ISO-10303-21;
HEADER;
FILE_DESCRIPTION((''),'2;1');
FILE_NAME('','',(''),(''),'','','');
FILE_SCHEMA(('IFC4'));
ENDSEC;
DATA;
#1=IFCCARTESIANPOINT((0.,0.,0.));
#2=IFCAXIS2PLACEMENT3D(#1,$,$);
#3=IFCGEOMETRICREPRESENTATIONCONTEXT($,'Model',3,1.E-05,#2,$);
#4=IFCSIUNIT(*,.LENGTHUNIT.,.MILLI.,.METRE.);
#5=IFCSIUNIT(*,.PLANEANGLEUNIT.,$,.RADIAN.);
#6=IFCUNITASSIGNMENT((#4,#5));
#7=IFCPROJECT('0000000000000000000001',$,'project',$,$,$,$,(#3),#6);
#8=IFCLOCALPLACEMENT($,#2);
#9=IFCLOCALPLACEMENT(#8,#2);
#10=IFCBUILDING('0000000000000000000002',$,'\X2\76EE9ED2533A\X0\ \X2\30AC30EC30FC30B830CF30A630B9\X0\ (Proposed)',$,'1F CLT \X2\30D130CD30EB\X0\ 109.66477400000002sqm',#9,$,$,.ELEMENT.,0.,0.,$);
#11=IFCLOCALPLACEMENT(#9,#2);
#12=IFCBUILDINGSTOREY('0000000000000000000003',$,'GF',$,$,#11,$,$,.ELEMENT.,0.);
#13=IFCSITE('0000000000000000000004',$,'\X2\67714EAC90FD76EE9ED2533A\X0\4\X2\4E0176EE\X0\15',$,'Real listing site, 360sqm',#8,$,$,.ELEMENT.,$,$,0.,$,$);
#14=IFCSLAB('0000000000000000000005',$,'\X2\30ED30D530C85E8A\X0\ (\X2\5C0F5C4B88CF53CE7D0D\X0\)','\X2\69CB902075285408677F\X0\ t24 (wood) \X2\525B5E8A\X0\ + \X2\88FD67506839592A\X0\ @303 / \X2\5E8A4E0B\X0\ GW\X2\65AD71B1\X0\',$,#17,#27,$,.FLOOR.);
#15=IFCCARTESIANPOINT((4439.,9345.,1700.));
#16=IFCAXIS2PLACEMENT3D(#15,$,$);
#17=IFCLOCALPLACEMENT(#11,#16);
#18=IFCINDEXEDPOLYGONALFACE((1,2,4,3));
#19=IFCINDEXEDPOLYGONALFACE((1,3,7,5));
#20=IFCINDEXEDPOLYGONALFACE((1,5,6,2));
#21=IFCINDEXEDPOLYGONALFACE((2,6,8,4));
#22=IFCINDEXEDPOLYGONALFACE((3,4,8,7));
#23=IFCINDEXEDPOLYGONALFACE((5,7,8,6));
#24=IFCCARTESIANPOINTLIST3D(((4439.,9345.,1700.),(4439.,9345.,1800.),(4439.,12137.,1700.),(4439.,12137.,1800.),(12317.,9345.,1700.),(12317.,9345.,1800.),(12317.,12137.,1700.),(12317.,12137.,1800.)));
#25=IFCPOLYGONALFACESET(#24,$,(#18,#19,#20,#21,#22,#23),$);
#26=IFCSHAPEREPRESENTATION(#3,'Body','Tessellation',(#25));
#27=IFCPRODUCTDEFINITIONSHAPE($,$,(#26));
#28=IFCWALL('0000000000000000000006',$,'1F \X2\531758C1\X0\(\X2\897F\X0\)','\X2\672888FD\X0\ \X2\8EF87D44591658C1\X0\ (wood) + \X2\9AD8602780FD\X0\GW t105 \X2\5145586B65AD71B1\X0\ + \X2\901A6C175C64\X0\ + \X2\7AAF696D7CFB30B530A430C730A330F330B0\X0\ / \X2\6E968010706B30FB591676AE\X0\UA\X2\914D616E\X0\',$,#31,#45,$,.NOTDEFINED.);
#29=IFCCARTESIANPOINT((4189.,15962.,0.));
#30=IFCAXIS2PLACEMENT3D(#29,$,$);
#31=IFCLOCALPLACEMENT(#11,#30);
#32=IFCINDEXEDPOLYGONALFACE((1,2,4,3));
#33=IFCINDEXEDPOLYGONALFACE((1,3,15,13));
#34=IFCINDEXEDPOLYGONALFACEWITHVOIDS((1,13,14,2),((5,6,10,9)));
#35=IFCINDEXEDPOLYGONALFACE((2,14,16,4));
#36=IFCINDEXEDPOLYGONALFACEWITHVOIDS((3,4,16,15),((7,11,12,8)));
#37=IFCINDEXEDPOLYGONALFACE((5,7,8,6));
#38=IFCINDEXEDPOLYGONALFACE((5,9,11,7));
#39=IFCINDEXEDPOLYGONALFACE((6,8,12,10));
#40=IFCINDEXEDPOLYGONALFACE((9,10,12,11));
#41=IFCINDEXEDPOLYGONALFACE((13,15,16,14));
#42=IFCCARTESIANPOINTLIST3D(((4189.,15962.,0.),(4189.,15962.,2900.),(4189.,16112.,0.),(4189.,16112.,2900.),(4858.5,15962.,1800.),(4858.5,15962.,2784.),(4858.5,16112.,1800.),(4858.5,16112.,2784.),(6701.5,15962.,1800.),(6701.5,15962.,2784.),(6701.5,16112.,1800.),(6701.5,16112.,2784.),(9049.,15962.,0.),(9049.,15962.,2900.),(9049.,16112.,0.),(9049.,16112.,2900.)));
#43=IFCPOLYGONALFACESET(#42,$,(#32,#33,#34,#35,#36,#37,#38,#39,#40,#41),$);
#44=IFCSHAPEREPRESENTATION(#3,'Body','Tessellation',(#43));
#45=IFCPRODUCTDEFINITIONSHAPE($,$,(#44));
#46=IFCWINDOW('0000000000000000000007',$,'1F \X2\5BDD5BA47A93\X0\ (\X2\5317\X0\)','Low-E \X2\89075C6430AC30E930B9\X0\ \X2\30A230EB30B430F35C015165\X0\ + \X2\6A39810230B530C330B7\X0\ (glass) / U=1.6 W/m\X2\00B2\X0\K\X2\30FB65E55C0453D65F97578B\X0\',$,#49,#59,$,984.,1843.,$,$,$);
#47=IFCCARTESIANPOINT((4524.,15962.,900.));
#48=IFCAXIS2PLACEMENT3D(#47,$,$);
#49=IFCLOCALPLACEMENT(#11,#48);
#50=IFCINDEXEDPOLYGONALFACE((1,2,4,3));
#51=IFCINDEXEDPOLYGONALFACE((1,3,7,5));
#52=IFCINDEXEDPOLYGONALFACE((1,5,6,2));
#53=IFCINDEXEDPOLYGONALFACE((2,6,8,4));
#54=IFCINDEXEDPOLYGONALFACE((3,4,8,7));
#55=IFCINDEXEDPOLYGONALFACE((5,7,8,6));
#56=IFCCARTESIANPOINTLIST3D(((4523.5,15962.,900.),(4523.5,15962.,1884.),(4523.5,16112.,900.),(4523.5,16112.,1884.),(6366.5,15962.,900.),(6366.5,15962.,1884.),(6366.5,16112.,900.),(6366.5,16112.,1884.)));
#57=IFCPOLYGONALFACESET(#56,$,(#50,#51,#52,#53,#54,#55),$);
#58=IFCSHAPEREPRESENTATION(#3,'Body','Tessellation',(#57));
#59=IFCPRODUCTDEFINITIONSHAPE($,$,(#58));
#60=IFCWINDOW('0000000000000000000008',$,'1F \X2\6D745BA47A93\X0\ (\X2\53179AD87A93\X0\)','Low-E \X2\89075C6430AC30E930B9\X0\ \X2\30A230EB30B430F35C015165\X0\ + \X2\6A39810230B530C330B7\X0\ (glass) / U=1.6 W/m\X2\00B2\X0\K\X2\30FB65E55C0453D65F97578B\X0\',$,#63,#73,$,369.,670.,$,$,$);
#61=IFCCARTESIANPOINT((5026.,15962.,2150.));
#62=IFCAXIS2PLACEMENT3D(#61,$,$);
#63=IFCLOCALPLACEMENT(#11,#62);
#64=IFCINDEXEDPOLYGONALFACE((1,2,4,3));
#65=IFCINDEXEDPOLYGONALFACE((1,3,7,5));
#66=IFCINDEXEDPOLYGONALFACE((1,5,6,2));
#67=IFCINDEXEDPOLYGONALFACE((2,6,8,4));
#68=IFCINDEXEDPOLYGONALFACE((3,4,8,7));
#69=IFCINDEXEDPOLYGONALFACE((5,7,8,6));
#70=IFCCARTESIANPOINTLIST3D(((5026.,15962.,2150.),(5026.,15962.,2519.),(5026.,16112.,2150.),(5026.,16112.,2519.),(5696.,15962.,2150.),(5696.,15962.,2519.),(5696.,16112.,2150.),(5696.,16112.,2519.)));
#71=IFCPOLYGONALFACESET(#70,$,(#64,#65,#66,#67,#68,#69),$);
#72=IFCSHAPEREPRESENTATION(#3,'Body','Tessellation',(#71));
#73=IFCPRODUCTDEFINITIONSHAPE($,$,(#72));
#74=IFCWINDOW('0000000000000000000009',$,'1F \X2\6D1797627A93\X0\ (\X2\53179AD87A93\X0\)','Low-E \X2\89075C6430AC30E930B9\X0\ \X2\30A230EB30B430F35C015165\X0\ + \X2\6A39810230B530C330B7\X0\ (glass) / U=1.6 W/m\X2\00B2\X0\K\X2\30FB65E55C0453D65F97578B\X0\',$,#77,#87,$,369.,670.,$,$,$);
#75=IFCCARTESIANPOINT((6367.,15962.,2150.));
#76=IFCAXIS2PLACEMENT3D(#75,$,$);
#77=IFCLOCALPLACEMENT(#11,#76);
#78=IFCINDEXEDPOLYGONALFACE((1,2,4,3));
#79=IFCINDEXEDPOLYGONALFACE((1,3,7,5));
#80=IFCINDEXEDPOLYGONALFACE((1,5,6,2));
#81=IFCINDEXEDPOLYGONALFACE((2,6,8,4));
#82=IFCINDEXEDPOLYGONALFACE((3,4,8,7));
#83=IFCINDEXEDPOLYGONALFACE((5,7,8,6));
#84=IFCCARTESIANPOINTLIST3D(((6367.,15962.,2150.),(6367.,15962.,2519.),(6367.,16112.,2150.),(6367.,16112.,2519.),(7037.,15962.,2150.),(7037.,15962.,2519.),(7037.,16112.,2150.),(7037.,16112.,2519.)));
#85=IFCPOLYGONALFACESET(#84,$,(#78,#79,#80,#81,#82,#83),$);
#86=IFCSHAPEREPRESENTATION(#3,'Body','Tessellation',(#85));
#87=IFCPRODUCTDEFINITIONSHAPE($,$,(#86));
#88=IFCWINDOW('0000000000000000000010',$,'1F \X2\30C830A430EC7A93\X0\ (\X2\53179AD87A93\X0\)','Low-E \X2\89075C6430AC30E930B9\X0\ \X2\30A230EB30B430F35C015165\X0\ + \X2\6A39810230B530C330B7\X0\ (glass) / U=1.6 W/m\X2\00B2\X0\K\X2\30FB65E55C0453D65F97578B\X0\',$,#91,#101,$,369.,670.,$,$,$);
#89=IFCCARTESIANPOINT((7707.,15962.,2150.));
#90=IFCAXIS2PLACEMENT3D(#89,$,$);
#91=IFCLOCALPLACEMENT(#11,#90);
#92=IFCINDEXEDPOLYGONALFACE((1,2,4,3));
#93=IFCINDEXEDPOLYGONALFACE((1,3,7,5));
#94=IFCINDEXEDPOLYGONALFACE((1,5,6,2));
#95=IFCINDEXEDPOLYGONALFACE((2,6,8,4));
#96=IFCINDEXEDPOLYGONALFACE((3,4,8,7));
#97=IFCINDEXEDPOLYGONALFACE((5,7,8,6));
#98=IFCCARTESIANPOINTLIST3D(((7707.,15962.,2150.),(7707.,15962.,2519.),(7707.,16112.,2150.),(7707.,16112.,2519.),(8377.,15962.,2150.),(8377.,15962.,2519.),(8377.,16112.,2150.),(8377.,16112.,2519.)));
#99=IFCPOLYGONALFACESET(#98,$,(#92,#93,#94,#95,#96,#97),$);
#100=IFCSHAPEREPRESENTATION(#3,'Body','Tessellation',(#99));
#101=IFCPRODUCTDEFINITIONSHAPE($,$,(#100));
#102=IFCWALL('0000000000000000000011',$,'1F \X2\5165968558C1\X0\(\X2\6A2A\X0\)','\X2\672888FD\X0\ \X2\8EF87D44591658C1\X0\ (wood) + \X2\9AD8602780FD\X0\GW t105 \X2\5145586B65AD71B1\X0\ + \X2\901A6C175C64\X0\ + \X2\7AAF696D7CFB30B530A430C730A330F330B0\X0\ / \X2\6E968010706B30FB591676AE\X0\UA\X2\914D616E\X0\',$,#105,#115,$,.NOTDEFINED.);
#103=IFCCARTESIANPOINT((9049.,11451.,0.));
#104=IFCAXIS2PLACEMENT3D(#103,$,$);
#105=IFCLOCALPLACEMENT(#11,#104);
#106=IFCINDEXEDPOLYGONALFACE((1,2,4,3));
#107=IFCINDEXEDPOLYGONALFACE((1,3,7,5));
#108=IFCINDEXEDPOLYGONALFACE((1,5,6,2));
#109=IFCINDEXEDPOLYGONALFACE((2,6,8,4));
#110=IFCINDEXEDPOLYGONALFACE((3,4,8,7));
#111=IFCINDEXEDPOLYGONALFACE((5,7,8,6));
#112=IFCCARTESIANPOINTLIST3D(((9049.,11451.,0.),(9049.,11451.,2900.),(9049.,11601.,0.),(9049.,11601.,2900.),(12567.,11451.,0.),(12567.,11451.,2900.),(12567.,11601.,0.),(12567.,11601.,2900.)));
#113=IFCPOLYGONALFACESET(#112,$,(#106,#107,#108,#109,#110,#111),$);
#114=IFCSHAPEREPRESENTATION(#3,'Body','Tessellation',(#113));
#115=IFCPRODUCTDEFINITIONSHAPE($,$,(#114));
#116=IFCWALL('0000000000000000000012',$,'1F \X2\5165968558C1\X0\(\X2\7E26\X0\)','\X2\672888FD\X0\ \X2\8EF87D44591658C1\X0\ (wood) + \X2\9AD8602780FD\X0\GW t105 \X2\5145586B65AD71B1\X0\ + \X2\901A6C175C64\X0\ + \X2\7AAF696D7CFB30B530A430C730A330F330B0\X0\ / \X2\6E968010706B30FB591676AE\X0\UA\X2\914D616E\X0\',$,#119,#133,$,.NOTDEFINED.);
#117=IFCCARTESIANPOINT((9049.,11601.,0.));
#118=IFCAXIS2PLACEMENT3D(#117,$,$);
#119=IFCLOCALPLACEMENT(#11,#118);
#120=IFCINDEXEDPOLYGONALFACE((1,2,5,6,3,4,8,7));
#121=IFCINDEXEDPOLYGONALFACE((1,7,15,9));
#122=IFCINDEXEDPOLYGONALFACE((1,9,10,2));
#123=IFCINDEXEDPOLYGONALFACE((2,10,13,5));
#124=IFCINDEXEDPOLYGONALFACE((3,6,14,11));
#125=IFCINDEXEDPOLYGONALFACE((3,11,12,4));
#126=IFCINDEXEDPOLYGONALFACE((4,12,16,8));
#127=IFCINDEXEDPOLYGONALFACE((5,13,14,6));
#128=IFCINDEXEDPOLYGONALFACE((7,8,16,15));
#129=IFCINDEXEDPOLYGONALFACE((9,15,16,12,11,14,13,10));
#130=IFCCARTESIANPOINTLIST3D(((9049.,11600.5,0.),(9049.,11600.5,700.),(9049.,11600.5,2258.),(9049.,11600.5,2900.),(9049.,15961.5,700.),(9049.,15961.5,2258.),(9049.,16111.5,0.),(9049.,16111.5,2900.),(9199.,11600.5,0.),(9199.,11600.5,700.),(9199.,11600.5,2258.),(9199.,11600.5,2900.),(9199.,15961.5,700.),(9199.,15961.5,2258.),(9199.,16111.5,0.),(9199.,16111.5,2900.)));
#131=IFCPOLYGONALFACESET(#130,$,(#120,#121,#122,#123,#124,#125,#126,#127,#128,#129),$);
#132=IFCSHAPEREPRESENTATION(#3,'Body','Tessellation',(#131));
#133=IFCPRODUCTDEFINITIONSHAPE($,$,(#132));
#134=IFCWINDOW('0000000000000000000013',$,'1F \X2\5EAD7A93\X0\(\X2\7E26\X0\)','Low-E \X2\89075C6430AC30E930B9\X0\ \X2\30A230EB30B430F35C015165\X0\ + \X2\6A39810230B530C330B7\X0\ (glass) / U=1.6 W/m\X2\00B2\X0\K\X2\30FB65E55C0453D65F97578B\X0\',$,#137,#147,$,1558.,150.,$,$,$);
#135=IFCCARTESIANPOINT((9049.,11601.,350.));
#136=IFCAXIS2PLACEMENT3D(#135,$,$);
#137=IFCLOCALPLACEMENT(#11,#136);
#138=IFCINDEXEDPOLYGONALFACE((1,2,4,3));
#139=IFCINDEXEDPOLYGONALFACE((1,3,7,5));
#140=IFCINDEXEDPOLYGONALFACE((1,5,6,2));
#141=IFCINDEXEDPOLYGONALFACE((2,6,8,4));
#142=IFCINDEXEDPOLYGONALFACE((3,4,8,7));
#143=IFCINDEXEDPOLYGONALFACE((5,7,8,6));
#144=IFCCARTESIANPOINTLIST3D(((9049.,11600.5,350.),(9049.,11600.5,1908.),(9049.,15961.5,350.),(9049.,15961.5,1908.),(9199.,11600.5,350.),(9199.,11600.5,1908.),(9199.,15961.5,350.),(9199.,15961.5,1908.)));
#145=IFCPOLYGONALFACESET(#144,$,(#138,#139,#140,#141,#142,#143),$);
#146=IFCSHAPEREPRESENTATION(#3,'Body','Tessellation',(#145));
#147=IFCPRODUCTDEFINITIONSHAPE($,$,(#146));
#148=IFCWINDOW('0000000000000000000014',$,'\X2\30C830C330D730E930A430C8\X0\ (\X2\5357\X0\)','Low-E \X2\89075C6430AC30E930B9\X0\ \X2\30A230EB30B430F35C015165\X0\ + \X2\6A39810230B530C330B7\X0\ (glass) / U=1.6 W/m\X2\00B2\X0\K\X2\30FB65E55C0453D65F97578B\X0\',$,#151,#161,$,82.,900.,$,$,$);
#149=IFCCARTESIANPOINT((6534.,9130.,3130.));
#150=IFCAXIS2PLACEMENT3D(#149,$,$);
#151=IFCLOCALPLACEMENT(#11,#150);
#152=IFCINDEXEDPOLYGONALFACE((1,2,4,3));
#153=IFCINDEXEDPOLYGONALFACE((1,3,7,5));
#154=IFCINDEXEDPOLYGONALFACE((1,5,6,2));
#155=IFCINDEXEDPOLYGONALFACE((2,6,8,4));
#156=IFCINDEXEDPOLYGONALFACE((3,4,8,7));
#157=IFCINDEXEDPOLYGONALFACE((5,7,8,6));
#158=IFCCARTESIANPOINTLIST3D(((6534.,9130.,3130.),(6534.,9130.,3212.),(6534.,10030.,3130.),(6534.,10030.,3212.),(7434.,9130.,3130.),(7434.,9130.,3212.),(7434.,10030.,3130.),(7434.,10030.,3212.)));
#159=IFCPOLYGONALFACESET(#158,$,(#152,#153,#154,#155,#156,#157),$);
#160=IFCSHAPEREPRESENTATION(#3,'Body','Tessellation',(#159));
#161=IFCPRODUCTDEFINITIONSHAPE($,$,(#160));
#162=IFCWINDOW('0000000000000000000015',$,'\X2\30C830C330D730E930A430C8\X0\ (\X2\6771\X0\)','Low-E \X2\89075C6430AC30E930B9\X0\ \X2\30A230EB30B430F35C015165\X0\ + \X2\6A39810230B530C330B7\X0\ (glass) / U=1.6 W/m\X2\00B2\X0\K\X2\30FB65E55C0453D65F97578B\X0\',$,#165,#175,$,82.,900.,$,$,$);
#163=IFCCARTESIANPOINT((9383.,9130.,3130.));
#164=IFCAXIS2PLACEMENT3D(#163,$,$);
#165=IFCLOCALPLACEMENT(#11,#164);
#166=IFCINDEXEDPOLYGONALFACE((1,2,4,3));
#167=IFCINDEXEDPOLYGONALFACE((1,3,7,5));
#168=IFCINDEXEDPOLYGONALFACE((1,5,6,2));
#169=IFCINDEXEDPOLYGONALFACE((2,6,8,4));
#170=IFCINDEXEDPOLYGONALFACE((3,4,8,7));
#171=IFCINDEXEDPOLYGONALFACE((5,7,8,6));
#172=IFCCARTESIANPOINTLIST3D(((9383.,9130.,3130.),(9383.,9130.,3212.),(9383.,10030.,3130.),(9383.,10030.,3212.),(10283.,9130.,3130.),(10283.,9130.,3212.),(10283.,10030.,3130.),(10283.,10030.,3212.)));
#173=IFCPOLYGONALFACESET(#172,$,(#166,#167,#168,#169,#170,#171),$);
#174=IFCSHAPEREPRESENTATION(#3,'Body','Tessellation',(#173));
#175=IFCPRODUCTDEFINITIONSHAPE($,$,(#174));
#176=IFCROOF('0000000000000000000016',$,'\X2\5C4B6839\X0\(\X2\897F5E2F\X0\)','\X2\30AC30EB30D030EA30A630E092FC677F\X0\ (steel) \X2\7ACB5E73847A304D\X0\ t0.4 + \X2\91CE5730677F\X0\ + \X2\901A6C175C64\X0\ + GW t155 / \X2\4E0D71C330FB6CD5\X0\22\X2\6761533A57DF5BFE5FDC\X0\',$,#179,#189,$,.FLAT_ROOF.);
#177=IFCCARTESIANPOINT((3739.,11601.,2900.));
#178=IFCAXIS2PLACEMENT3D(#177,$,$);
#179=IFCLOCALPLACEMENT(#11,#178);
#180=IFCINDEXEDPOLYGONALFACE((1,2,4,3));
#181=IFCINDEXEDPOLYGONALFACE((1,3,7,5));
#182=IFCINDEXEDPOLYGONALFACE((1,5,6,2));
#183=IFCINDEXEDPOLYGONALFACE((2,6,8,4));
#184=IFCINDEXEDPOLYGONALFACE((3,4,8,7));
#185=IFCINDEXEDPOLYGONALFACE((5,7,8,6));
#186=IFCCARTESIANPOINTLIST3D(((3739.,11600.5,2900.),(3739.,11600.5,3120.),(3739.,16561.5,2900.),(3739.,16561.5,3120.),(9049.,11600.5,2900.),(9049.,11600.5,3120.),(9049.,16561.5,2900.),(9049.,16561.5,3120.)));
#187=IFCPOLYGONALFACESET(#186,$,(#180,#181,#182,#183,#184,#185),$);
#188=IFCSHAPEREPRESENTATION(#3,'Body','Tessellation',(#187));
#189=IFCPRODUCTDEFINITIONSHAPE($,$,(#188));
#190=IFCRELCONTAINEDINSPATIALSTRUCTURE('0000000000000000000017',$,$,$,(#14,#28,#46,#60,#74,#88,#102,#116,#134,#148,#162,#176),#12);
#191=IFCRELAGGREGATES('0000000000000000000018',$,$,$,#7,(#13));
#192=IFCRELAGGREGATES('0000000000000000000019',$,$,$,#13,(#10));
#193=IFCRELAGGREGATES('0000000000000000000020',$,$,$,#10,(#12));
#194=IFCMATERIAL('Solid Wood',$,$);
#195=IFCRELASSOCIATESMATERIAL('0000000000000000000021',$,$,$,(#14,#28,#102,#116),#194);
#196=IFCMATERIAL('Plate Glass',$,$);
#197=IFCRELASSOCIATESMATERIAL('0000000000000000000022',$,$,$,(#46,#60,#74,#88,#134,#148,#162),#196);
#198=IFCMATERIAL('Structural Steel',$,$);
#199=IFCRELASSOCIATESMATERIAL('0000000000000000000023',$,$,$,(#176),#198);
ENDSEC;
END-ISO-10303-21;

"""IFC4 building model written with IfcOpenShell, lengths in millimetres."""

from ifc_helpers import new_model, si_unit, frame, frame_2d, origin, place, context, project, spatial, rectangle, extrude, material, element, fill, save


model = new_model("IFC4")

# Units and contexts
model_context = context("Model", 3, precision=1e-05, world=origin())
ifc_project = project(units=[si_unit("LENGTHUNIT", "METRE", prefix="MILLI"), si_unit("PLANEANGLEUNIT", "RADIAN")], contexts=[model_context])

# Site, building, storey
site_placement = place(None, origin())
site = spatial("IfcSite", under=ifc_project, at=site_placement, Name="東京都目黒区4丁目15", ObjectType="Real listing site, 360sqm", CompositionType="ELEMENT", RefElevation=0.0)
building_placement = place(site_placement, origin())
building = spatial("IfcBuilding", under=site, at=building_placement, Name="目黒区 ガレージハウス (Proposed)", ObjectType="1F CLT パネル 109.66477400000002sqm", CompositionType="ELEMENT", ElevationOfRefHeight=0.0, ElevationOfTerrain=0.0)
storey_placement = place(building_placement, origin())
storey = spatial("IfcBuildingStorey", under=building, at=storey_placement, Name="GF", CompositionType="ELEMENT", Elevation=0.0)

# Slab
ifc_material_1 = material(Name="Solid Wood")
slab_1_placement = place(storey_placement, frame((4439.0, 9345.0, 1700.0)))
element("IfcSlab", 1, at=slab_1_placement, inside=storey, material=ifc_material_1, Name="ロフト床 (小屋裏収納)", Description="構造用合板 t24 (wood) 剛床 + 製材根太 @303 / 床下 GW断熱", PredefinedType="FLOOR", context=model_context, shape_type="SweptSolid", body=[
    extrude(rectangle(XDim=7878.0, YDim=2792.0, at=frame_2d((3939.0, 1396.0))), frame((4439.0, 9345.0, 1700.0)), (0.0, 0.0, 1.0), 100.0),
])

# Wall, openings, windows
wall_1_placement = place(storey_placement, frame((4189.0, 15962.0, 0.0)))
wall_1 = element("IfcWall", 2, at=wall_1_placement, inside=storey, material=ifc_material_1, Name="1F 北壁(西)", Description="木製 軸組外壁 (wood) + 高性能GW t105 充填断熱 + 通気層 + 窯業系サイディング / 準耐火・外皮UA配慮", PredefinedType="NOTDEFINED", context=model_context, shape_type="SweptSolid", body=[
    extrude(rectangle(XDim=4860.0, YDim=150.0, at=frame_2d((2430.0, 75.0))), frame((4189.0, 15962.0, 0.0)), (0.0, 0.0, 1.0), 2900.0),
])
opening_1_placement = place(storey_placement, frame((4524.0, 15962.0, 900.0)))
opening_1 = element("IfcOpeningElement", 3, at=opening_1_placement, cuts=wall_1, PredefinedType="NOTDEFINED", context=model_context, shape_type="SweptSolid", body=[
    extrude(rectangle(XDim=1843.0, YDim=150.0, at=frame_2d((921.0, 75.0))), frame((4524.0, 15962.0, 900.0)), (0.0, 0.0, 1.0), 984.0),
])
opening_2_placement = place(storey_placement, frame((5026.0, 15962.0, 2150.0)))
opening_2 = element("IfcOpeningElement", 4, at=opening_2_placement, cuts=wall_1, PredefinedType="NOTDEFINED", context=model_context, shape_type="SweptSolid", body=[
    extrude(rectangle(XDim=670.0, YDim=150.0, at=frame_2d((335.0, 75.0))), frame((5026.0, 15962.0, 2150.0)), (0.0, 0.0, 1.0), 369.0),
])
opening_3_placement = place(storey_placement, frame((6367.0, 15962.0, 2150.0)))
opening_3 = element("IfcOpeningElement", 5, at=opening_3_placement, cuts=wall_1, PredefinedType="NOTDEFINED", context=model_context, shape_type="SweptSolid", body=[
    extrude(rectangle(XDim=670.0, YDim=150.0, at=frame_2d((335.0, 75.0))), frame((6367.0, 15962.0, 2150.0)), (0.0, 0.0, 1.0), 369.0),
])
opening_4_placement = place(storey_placement, frame((7707.0, 15962.0, 2150.0)))
opening_4 = element("IfcOpeningElement", 6, at=opening_4_placement, cuts=wall_1, PredefinedType="NOTDEFINED", context=model_context, shape_type="SweptSolid", body=[
    extrude(rectangle(XDim=670.0, YDim=150.0, at=frame_2d((335.0, 75.0))), frame((7707.0, 15962.0, 2150.0)), (0.0, 0.0, 1.0), 369.0),
])
ifc_material_2 = material(Name="Plate Glass")
window_1_placement = place(storey_placement, frame((4524.0, 15962.0, 900.0)))
window_1 = element("IfcWindow", 7, at=window_1_placement, inside=storey, material=ifc_material_2, Name="1F 寝室窓 (北)", Description="Low-E 複層ガラス アルゴン封入 + 樹脂サッシ (glass) / U=1.6 W/m²K・日射取得型", OverallHeight=984.0, OverallWidth=1843.0, context=model_context, shape_type="SweptSolid", body=[
    extrude(rectangle(XDim=1843.0, YDim=150.0, at=frame_2d((921.0, 75.0))), frame((4524.0, 15962.0, 900.0)), (0.0, 0.0, 1.0), 984.0),
])
fill(opening_1, window_1)
window_2_placement = place(storey_placement, frame((5026.0, 15962.0, 2150.0)))
window_2 = element("IfcWindow", 8, at=window_2_placement, inside=storey, material=ifc_material_2, Name="1F 浴室窓 (北高窓)", Description="Low-E 複層ガラス アルゴン封入 + 樹脂サッシ (glass) / U=1.6 W/m²K・日射取得型", OverallHeight=369.0, OverallWidth=670.0, context=model_context, shape_type="SweptSolid", body=[
    extrude(rectangle(XDim=670.0, YDim=150.0, at=frame_2d((335.0, 75.0))), frame((5026.0, 15962.0, 2150.0)), (0.0, 0.0, 1.0), 369.0),
])
fill(opening_2, window_2)
window_3_placement = place(storey_placement, frame((6367.0, 15962.0, 2150.0)))
window_3 = element("IfcWindow", 9, at=window_3_placement, inside=storey, material=ifc_material_2, Name="1F 洗面窓 (北高窓)", Description="Low-E 複層ガラス アルゴン封入 + 樹脂サッシ (glass) / U=1.6 W/m²K・日射取得型", OverallHeight=369.0, OverallWidth=670.0, context=model_context, shape_type="SweptSolid", body=[
    extrude(rectangle(XDim=670.0, YDim=150.0, at=frame_2d((335.0, 75.0))), frame((6367.0, 15962.0, 2150.0)), (0.0, 0.0, 1.0), 369.0),
])
fill(opening_3, window_3)
window_4_placement = place(storey_placement, frame((7707.0, 15962.0, 2150.0)))
window_4 = element("IfcWindow", 10, at=window_4_placement, inside=storey, material=ifc_material_2, Name="1F トイレ窓 (北高窓)", Description="Low-E 複層ガラス アルゴン封入 + 樹脂サッシ (glass) / U=1.6 W/m²K・日射取得型", OverallHeight=369.0, OverallWidth=670.0, context=model_context, shape_type="SweptSolid", body=[
    extrude(rectangle(XDim=670.0, YDim=150.0, at=frame_2d((335.0, 75.0))), frame((7707.0, 15962.0, 2150.0)), (0.0, 0.0, 1.0), 369.0),
])
fill(opening_4, window_4)

# Wall
wall_2_placement = place(storey_placement, frame((9049.0, 11451.0, 0.0)))
element("IfcWall", 11, at=wall_2_placement, inside=storey, material=ifc_material_1, Name="1F 入隅壁(横)", Description="木製 軸組外壁 (wood) + 高性能GW t105 充填断熱 + 通気層 + 窯業系サイディング / 準耐火・外皮UA配慮", PredefinedType="NOTDEFINED", context=model_context, shape_type="SweptSolid", body=[
    extrude(rectangle(XDim=3518.0, YDim=150.0, at=frame_2d((1759.0, 75.0))), frame((9049.0, 11451.0, 0.0)), (0.0, 0.0, 1.0), 2900.0),
])

# Wall, opening, window
wall_3_placement = place(storey_placement, frame((9049.0, 11601.0, 0.0)))
wall_3 = element("IfcWall", 12, at=wall_3_placement, inside=storey, material=ifc_material_1, Name="1F 入隅壁(縦)", Description="木製 軸組外壁 (wood) + 高性能GW t105 充填断熱 + 通気層 + 窯業系サイディング / 準耐火・外皮UA配慮", PredefinedType="NOTDEFINED", context=model_context, shape_type="SweptSolid", body=[
    extrude(rectangle(XDim=150.0, YDim=4511.0, at=frame_2d((75.0, 2255.0))), frame((9049.0, 11601.0, 0.0)), (0.0, 0.0, 1.0), 2900.0),
])
opening_5_placement = place(storey_placement, frame((9049.0, 11601.0, 350.0)))
opening_5 = element("IfcOpeningElement", 13, at=opening_5_placement, cuts=wall_3, PredefinedType="NOTDEFINED", context=model_context, shape_type="SweptSolid", body=[
    extrude(rectangle(XDim=150.0, YDim=4361.0, at=frame_2d((75.0, 2180.0))), frame((9049.0, 11601.0, 350.0)), (0.0, 0.0, 1.0), 1558.0),
])
window_5_placement = place(storey_placement, frame((9049.0, 11601.0, 350.0)))
window_5 = element("IfcWindow", 14, at=window_5_placement, inside=storey, material=ifc_material_2, Name="1F 庭窓(縦)", Description="Low-E 複層ガラス アルゴン封入 + 樹脂サッシ (glass) / U=1.6 W/m²K・日射取得型", OverallHeight=1558.0, OverallWidth=150.0, context=model_context, shape_type="SweptSolid", body=[
    extrude(rectangle(XDim=150.0, YDim=4361.0, at=frame_2d((75.0, 2180.0))), frame((9049.0, 11601.0, 350.0)), (0.0, 0.0, 1.0), 1558.0),
])
fill(opening_5, window_5)

# Windows
window_6_placement = place(storey_placement, frame((6534.0, 9130.0, 3130.0)))
element("IfcWindow", 15, at=window_6_placement, inside=storey, material=ifc_material_2, Name="トップライト (南)", Description="Low-E 複層ガラス アルゴン封入 + 樹脂サッシ (glass) / U=1.6 W/m²K・日射取得型", OverallHeight=82.0, OverallWidth=900.0, context=model_context, shape_type="SweptSolid", body=[
    extrude(rectangle(XDim=900.0, YDim=900.0, at=frame_2d((450.0, 450.0))), frame((6534.0, 9130.0, 3130.0)), (0.0, 0.0, 1.0), 82.0),
])
window_7_placement = place(storey_placement, frame((9383.0, 9130.0, 3130.0)))
element("IfcWindow", 16, at=window_7_placement, inside=storey, material=ifc_material_2, Name="トップライト (東)", Description="Low-E 複層ガラス アルゴン封入 + 樹脂サッシ (glass) / U=1.6 W/m²K・日射取得型", OverallHeight=82.0, OverallWidth=900.0, context=model_context, shape_type="SweptSolid", body=[
    extrude(rectangle(XDim=900.0, YDim=900.0, at=frame_2d((450.0, 450.0))), frame((9383.0, 9130.0, 3130.0)), (0.0, 0.0, 1.0), 82.0),
])

# Roof
ifc_material_3 = material(Name="Structural Steel")
roof_placement = place(storey_placement, frame((3739.0, 11601.0, 2900.0)))
element("IfcRoof", 17, at=roof_placement, inside=storey, material=ifc_material_3, Name="屋根(西帯)", Description="ガルバリウム鋼板 (steel) 立平葺き t0.4 + 野地板 + 通気層 + GW t155 / 不燃・法22条区域対応", PredefinedType="FLAT_ROOF", context=model_context, shape_type="SweptSolid", body=[
    extrude(rectangle(XDim=5310.0, YDim=4961.0, at=frame_2d((2655.0, 2480.0))), frame((3739.0, 11601.0, 2900.0)), (0.0, 0.0, 1.0), 220.0),
])

save(model, "model.ifc")
